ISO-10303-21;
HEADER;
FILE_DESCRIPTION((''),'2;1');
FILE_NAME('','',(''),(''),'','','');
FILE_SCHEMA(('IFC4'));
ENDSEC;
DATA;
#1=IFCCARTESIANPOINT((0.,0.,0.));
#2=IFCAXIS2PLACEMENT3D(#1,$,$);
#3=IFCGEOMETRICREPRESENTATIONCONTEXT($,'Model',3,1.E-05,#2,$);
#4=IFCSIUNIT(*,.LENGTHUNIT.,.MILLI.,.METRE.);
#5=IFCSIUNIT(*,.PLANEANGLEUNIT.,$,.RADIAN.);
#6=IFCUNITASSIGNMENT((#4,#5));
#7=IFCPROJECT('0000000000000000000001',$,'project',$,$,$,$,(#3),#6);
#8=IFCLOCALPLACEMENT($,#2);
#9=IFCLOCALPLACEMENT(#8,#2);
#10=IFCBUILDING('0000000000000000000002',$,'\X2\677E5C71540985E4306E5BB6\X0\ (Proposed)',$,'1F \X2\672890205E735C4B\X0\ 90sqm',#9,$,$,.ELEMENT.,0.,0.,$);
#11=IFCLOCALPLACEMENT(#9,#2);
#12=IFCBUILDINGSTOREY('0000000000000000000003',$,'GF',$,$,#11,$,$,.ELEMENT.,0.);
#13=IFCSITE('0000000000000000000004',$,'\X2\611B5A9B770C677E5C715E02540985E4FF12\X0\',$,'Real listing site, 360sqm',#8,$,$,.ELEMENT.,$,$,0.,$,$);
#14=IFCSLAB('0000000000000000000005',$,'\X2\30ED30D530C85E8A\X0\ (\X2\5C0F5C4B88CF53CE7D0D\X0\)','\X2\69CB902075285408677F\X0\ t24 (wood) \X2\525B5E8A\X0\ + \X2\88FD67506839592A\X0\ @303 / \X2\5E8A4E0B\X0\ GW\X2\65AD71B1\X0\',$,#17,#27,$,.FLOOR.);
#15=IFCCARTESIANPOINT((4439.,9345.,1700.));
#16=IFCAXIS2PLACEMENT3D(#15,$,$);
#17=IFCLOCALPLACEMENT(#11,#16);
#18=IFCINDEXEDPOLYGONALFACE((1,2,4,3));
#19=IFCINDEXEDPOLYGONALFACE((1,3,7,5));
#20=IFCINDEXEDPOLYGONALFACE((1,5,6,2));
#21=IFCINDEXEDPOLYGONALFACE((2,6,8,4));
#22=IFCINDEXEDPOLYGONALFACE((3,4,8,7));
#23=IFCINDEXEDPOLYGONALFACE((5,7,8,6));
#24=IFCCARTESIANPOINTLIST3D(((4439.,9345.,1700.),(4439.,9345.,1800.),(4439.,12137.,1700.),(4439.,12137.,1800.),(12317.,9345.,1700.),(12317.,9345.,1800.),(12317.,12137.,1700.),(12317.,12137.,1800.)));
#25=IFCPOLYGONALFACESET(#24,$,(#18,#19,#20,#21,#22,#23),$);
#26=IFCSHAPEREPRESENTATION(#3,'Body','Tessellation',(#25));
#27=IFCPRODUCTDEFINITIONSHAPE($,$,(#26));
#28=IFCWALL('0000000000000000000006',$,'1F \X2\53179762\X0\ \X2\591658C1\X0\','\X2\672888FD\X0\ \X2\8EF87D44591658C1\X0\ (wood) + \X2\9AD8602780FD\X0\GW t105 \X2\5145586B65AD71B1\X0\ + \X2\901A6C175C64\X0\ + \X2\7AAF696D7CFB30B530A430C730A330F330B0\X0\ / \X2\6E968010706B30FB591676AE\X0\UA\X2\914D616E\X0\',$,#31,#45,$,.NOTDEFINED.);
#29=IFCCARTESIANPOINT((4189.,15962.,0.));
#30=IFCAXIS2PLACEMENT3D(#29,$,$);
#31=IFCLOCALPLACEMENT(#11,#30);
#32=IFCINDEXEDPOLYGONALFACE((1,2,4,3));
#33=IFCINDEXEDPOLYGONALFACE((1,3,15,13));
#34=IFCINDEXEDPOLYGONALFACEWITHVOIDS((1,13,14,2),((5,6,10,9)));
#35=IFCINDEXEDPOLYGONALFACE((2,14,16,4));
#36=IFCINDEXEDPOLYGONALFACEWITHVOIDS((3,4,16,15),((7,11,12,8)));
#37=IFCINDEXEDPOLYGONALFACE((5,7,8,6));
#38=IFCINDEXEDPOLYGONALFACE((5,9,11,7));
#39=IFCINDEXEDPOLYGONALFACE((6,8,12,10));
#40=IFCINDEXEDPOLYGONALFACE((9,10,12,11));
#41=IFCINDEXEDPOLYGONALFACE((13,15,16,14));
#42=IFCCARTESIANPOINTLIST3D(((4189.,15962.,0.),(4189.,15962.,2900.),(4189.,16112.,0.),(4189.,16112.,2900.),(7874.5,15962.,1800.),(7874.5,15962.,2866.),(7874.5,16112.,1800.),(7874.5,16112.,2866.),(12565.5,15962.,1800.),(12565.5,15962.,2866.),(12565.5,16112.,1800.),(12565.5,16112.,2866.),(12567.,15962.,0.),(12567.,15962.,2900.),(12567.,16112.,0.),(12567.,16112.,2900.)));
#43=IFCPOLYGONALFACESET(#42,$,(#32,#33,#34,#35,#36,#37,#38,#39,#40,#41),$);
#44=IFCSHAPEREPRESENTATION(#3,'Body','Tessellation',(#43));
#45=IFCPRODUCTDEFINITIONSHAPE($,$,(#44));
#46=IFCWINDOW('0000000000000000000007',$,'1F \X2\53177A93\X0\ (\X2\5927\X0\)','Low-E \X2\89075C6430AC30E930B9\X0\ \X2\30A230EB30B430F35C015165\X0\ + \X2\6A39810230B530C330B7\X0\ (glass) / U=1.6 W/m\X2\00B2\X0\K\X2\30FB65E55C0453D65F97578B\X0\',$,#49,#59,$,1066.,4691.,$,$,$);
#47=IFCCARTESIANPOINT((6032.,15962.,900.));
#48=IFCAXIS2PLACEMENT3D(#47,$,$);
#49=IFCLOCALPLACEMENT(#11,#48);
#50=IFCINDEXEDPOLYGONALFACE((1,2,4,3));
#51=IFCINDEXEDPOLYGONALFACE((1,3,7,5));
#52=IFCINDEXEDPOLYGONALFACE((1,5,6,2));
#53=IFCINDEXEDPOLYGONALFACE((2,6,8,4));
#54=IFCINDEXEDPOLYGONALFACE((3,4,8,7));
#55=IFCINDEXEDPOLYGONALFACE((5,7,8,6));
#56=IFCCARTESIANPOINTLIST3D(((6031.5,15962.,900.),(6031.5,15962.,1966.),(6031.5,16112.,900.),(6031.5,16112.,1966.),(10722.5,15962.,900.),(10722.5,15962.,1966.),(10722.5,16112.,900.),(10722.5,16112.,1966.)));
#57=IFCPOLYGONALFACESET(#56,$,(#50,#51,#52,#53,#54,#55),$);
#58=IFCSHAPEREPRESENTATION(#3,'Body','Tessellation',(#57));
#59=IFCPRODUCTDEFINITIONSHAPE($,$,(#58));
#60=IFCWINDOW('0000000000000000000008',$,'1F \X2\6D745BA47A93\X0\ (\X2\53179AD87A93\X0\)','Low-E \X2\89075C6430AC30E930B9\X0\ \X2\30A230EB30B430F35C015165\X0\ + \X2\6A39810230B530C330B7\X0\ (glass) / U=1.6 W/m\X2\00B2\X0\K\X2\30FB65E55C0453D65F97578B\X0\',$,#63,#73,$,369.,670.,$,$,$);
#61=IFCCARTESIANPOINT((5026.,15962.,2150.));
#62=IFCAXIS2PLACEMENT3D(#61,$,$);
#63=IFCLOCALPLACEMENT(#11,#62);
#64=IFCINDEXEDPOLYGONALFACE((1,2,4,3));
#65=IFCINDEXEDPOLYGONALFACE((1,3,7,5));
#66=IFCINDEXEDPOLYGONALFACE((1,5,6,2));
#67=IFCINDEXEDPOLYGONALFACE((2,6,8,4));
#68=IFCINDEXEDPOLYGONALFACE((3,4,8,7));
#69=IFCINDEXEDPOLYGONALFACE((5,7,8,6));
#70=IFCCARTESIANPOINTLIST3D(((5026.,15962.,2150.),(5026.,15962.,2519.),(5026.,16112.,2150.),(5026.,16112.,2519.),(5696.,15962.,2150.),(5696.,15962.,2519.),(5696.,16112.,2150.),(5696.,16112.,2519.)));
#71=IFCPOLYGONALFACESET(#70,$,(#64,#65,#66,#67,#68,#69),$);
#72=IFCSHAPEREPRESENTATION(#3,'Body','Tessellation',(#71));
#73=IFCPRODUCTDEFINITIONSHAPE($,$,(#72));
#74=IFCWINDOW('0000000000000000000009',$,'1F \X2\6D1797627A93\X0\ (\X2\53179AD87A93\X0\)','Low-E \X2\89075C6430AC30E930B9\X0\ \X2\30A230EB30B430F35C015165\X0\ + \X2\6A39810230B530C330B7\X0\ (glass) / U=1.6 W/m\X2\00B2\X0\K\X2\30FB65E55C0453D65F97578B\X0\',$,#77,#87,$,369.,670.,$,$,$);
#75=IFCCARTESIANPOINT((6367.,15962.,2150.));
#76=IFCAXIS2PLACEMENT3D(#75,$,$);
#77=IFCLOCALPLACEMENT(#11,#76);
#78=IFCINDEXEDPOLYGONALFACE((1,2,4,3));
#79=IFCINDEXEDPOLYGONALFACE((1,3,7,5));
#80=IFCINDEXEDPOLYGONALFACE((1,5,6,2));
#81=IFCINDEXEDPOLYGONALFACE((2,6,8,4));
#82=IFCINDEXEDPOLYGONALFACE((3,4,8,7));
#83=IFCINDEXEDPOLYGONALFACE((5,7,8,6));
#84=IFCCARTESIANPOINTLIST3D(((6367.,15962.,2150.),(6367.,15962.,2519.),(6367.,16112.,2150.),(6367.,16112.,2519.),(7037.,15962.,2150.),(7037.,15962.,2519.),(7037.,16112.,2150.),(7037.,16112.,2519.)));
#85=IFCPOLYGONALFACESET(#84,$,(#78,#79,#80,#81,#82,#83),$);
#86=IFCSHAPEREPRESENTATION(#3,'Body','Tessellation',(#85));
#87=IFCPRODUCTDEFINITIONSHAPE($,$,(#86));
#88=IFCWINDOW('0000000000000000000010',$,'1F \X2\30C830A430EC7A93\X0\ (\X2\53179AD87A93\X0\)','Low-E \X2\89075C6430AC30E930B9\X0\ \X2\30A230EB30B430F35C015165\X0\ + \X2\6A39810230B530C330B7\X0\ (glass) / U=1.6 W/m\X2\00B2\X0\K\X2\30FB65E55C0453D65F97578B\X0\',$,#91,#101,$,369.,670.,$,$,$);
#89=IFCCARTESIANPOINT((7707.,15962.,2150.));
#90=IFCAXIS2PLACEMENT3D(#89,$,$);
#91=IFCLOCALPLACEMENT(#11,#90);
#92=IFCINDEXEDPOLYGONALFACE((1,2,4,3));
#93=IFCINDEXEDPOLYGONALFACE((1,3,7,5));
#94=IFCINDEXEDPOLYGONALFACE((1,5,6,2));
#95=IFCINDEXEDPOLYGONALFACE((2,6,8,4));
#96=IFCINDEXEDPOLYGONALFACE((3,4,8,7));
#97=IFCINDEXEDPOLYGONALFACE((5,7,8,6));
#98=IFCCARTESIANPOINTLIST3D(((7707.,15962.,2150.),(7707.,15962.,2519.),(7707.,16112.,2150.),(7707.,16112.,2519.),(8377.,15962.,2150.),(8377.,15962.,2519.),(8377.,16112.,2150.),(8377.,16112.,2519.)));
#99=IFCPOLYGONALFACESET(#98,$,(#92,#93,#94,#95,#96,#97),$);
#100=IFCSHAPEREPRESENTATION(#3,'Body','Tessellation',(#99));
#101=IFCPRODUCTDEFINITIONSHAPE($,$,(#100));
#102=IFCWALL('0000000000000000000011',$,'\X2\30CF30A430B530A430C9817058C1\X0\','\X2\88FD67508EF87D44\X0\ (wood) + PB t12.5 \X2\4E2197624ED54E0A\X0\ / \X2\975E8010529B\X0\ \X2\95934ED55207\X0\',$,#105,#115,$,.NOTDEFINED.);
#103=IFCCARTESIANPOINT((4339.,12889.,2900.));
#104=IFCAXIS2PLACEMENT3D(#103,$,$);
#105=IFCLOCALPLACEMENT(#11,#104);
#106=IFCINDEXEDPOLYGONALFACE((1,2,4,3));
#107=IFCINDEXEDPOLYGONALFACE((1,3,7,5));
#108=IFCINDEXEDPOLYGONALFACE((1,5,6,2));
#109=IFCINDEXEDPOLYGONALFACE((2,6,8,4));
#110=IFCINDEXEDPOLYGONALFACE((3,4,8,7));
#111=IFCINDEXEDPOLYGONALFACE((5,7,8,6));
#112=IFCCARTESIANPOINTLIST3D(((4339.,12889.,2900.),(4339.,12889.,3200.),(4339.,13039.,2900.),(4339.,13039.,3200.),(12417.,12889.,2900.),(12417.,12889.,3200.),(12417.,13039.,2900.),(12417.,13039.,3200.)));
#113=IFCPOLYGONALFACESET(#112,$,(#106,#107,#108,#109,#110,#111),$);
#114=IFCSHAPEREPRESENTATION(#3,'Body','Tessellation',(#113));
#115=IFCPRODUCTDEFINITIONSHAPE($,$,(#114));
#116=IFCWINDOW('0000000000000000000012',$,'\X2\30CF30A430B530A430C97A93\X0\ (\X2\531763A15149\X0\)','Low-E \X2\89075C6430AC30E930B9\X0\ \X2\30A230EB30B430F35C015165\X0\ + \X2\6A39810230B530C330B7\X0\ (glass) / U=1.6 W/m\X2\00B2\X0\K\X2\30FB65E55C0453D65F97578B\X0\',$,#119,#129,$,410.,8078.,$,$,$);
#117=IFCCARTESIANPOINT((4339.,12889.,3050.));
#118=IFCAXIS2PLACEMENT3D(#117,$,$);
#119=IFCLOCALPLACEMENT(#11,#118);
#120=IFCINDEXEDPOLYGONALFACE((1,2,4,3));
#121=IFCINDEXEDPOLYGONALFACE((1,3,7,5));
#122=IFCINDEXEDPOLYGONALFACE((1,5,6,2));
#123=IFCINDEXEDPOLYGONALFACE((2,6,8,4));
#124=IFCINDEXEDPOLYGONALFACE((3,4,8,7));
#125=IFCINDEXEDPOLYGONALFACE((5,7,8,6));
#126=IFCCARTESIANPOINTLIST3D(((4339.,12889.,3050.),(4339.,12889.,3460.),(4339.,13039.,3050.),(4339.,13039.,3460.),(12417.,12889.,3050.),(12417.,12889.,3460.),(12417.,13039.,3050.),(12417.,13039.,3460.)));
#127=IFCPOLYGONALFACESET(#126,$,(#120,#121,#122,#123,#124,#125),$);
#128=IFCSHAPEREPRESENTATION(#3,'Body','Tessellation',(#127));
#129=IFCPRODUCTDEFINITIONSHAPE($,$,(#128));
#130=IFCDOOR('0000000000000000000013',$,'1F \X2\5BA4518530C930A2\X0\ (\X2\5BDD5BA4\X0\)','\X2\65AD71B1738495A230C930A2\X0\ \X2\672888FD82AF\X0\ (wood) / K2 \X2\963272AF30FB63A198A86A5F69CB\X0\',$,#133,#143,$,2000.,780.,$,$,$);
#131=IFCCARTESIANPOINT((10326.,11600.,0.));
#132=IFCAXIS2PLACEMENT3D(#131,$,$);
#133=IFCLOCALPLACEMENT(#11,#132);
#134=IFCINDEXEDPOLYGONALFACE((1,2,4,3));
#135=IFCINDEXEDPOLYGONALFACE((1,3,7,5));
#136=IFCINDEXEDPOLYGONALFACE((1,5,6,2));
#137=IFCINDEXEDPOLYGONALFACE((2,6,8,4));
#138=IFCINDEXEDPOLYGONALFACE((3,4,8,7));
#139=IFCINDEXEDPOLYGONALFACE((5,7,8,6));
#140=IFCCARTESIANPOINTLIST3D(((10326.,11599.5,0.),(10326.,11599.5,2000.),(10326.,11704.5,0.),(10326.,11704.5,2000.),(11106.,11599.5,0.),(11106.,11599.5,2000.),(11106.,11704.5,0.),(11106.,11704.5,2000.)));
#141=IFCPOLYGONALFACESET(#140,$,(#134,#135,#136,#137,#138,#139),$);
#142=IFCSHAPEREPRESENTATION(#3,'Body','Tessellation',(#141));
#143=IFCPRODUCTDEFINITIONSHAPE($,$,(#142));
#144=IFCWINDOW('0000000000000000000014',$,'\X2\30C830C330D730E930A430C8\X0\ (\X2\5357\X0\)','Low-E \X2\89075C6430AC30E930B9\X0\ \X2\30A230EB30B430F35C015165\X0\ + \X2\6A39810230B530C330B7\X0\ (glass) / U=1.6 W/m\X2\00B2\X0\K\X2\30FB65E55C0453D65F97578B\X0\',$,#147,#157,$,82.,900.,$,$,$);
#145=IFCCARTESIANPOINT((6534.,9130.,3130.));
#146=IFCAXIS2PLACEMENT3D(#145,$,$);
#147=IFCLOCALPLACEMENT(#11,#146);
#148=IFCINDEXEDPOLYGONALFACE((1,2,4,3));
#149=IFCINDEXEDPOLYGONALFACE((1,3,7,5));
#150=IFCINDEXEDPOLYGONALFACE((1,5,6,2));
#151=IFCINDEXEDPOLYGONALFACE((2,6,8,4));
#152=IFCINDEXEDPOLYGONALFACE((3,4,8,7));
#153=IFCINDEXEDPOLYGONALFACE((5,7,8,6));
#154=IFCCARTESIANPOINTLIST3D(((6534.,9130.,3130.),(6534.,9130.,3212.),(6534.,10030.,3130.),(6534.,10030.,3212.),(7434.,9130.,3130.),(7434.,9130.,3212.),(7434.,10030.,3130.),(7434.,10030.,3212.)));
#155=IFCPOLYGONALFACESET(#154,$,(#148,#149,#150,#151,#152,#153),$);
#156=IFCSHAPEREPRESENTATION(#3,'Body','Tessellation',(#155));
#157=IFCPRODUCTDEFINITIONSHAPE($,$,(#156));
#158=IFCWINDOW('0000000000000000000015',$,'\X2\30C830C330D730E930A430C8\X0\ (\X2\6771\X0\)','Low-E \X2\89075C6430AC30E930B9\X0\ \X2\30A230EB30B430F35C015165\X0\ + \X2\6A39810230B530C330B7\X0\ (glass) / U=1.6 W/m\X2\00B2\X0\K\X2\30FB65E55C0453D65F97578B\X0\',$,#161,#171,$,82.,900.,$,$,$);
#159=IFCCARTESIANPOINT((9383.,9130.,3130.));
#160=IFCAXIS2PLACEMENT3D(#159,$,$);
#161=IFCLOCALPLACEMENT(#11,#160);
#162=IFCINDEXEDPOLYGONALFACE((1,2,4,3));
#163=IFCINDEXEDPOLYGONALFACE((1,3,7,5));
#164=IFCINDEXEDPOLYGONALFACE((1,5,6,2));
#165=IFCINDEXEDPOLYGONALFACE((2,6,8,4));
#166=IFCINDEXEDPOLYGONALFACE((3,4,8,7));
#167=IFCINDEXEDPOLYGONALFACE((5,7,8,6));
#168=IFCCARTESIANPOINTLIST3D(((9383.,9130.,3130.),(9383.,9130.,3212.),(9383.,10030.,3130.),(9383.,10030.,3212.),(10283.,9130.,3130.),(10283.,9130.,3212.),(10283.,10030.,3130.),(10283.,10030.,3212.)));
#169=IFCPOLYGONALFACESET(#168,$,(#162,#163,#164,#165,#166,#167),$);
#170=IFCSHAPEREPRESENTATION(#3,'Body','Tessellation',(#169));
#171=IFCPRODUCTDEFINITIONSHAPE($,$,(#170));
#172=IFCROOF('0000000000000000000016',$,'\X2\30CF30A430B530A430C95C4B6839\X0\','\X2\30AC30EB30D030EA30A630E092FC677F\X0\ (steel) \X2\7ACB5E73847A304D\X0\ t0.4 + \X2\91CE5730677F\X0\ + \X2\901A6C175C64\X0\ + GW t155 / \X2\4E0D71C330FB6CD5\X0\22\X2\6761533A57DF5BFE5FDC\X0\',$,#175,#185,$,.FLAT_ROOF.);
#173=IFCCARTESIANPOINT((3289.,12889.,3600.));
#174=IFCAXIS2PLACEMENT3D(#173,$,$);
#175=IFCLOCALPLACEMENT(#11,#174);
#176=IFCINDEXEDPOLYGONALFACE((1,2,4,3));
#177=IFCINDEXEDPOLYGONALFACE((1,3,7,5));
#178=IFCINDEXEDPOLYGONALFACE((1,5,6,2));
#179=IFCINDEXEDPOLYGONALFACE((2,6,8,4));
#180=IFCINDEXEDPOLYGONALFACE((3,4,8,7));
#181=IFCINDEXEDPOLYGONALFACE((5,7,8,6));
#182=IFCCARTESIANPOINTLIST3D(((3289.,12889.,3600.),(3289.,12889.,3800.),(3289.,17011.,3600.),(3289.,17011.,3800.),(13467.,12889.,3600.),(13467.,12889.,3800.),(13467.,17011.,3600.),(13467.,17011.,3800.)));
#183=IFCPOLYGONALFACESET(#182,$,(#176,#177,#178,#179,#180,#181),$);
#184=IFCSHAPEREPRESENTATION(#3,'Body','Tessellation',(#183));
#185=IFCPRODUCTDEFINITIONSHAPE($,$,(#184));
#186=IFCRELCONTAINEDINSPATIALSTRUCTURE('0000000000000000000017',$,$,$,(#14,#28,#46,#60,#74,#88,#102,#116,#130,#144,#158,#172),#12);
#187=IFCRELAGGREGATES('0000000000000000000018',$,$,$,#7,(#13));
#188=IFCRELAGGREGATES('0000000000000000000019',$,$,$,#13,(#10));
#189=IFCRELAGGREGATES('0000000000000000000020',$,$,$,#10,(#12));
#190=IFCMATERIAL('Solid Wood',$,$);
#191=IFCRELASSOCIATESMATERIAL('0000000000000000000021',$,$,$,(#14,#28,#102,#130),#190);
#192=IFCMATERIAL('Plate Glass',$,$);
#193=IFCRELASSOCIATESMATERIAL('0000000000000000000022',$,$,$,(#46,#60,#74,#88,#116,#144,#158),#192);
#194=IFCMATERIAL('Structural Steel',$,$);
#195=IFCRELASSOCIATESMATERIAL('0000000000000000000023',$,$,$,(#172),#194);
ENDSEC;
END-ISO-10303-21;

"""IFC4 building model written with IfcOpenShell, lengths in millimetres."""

from ifc_helpers import new_model, si_unit, frame, frame_2d, origin, place, context, project, spatial, rectangle, extrude, material, element, fill, save


model = new_model("IFC4")

# Units and contexts
model_context = context("Model", 3, precision=1e-05, world=origin())
ifc_project = project(units=[si_unit("LENGTHUNIT", "METRE", prefix="MILLI"), si_unit("PLANEANGLEUNIT", "RADIAN")], contexts=[model_context])

# Site, building, storey
site_placement = place(None, origin())
site = spatial("IfcSite", under=ifc_project, at=site_placement, Name="愛媛県松山市吉藤２", ObjectType="Real listing site, 360sqm", CompositionType="ELEMENT", RefElevation=0.0)
building_placement = place(site_placement, origin())
building = spatial("IfcBuilding", under=site, at=building_placement, Name="松山吉藤の家 (Proposed)", ObjectType="1F 木造平屋 90sqm", CompositionType="ELEMENT", ElevationOfRefHeight=0.0, ElevationOfTerrain=0.0)
storey_placement = place(building_placement, origin())
storey = spatial("IfcBuildingStorey", under=building, at=storey_placement, Name="GF", CompositionType="ELEMENT", Elevation=0.0)

# Slab
ifc_material_1 = material(Name="Solid Wood")
slab_placement = place(storey_placement, frame((4439.0, 9345.0, 1700.0)))
element("IfcSlab", 1, at=slab_placement, inside=storey, material=ifc_material_1, Name="ロフト床 (小屋裏収納)", Description="構造用合板 t24 (wood) 剛床 + 製材根太 @303 / 床下 GW断熱", PredefinedType="FLOOR", context=model_context, shape_type="SweptSolid", body=[
    extrude(rectangle(XDim=7878.0, YDim=2792.0, at=frame_2d((3939.0, 1396.0))), frame((4439.0, 9345.0, 1700.0)), (0.0, 0.0, 1.0), 100.0),
])

# Wall, openings, windows
wall_1_placement = place(storey_placement, frame((4189.0, 15962.0, 0.0)))
wall_1 = element("IfcWall", 2, at=wall_1_placement, inside=storey, material=ifc_material_1, Name="1F 北面 外壁", Description="木製 軸組外壁 (wood) + 高性能GW t105 充填断熱 + 通気層 + 窯業系サイディング / 準耐火・外皮UA配慮", PredefinedType="NOTDEFINED", context=model_context, shape_type="SweptSolid", body=[
    extrude(rectangle(XDim=8378.0, YDim=150.0, at=frame_2d((4189.0, 75.0))), frame((4189.0, 15962.0, 0.0)), (0.0, 0.0, 1.0), 2900.0),
])
opening_1_placement = place(storey_placement, frame((6032.0, 15962.0, 900.0)))
opening_1 = element("IfcOpeningElement", 3, at=opening_1_placement, cuts=wall_1, PredefinedType="NOTDEFINED", context=model_context, shape_type="SweptSolid", body=[
    extrude(rectangle(XDim=4691.0, YDim=150.0, at=frame_2d((2345.0, 75.0))), frame((6032.0, 15962.0, 900.0)), (0.0, 0.0, 1.0), 1066.0),
])
opening_2_placement = place(storey_placement, frame((5026.0, 15962.0, 2150.0)))
opening_2 = element("IfcOpeningElement", 4, at=opening_2_placement, cuts=wall_1, PredefinedType="NOTDEFINED", context=model_context, shape_type="SweptSolid", body=[
    extrude(rectangle(XDim=670.0, YDim=150.0, at=frame_2d((335.0, 75.0))), frame((5026.0, 15962.0, 2150.0)), (0.0, 0.0, 1.0), 369.0),
])
opening_3_placement = place(storey_placement, frame((6367.0, 15962.0, 2150.0)))
opening_3 = element("IfcOpeningElement", 5, at=opening_3_placement, cuts=wall_1, PredefinedType="NOTDEFINED", context=model_context, shape_type="SweptSolid", body=[
    extrude(rectangle(XDim=670.0, YDim=150.0, at=frame_2d((335.0, 75.0))), frame((6367.0, 15962.0, 2150.0)), (0.0, 0.0, 1.0), 369.0),
])
opening_4_placement = place(storey_placement, frame((7707.0, 15962.0, 2150.0)))
opening_4 = element("IfcOpeningElement", 6, at=opening_4_placement, cuts=wall_1, PredefinedType="NOTDEFINED", context=model_context, shape_type="SweptSolid", body=[
    extrude(rectangle(XDim=670.0, YDim=150.0, at=frame_2d((335.0, 75.0))), frame((7707.0, 15962.0, 2150.0)), (0.0, 0.0, 1.0), 369.0),
])
ifc_material_2 = material(Name="Plate Glass")
window_1_placement = place(storey_placement, frame((6032.0, 15962.0, 900.0)))
window_1 = element("IfcWindow", 7, at=window_1_placement, inside=storey, material=ifc_material_2, Name="1F 北窓 (大)", Description="Low-E 複層ガラス アルゴン封入 + 樹脂サッシ (glass) / U=1.6 W/m²K・日射取得型", OverallHeight=1066.0, OverallWidth=4691.0, context=model_context, shape_type="SweptSolid", body=[
    extrude(rectangle(XDim=4691.0, YDim=150.0, at=frame_2d((2345.0, 75.0))), frame((6032.0, 15962.0, 900.0)), (0.0, 0.0, 1.0), 1066.0),
])
fill(opening_1, window_1)
window_2_placement = place(storey_placement, frame((5026.0, 15962.0, 2150.0)))
window_2 = element("IfcWindow", 8, at=window_2_placement, inside=storey, material=ifc_material_2, Name="1F 浴室窓 (北高窓)", Description="Low-E 複層ガラス アルゴン封入 + 樹脂サッシ (glass) / U=1.6 W/m²K・日射取得型", OverallHeight=369.0, OverallWidth=670.0, context=model_context, shape_type="SweptSolid", body=[
    extrude(rectangle(XDim=670.0, YDim=150.0, at=frame_2d((335.0, 75.0))), frame((5026.0, 15962.0, 2150.0)), (0.0, 0.0, 1.0), 369.0),
])
fill(opening_2, window_2)
window_3_placement = place(storey_placement, frame((6367.0, 15962.0, 2150.0)))
window_3 = element("IfcWindow", 9, at=window_3_placement, inside=storey, material=ifc_material_2, Name="1F 洗面窓 (北高窓)", Description="Low-E 複層ガラス アルゴン封入 + 樹脂サッシ (glass) / U=1.6 W/m²K・日射取得型", OverallHeight=369.0, OverallWidth=670.0, context=model_context, shape_type="SweptSolid", body=[
    extrude(rectangle(XDim=670.0, YDim=150.0, at=frame_2d((335.0, 75.0))), frame((6367.0, 15962.0, 2150.0)), (0.0, 0.0, 1.0), 369.0),
])
fill(opening_3, window_3)
window_4_placement = place(storey_placement, frame((7707.0, 15962.0, 2150.0)))
window_4 = element("IfcWindow", 10, at=window_4_placement, inside=storey, material=ifc_material_2, Name="1F トイレ窓 (北高窓)", Description="Low-E 複層ガラス アルゴン封入 + 樹脂サッシ (glass) / U=1.6 W/m²K・日射取得型", OverallHeight=369.0, OverallWidth=670.0, context=model_context, shape_type="SweptSolid", body=[
    extrude(rectangle(XDim=670.0, YDim=150.0, at=frame_2d((335.0, 75.0))), frame((7707.0, 15962.0, 2150.0)), (0.0, 0.0, 1.0), 369.0),
])
fill(opening_4, window_4)

# Wall, opening, window
wall_2_placement = place(storey_placement, frame((4339.0, 12889.0, 2900.0)))
wall_2 = element("IfcWall", 11, at=wall_2_placement, inside=storey, material=ifc_material_1, Name="ハイサイド腰壁", Description="製材軸組 (wood) + PB t12.5 両面仕上 / 非耐力 間仕切", PredefinedType="NOTDEFINED", context=model_context, shape_type="SweptSolid", body=[
    extrude(rectangle(XDim=8078.0, YDim=150.0, at=frame_2d((4039.0, 75.0))), frame((4339.0, 12889.0, 2900.0)), (0.0, 0.0, 1.0), 700.0),
])
opening_5_placement = place(storey_placement, frame((4339.0, 12889.0, 3050.0)))
opening_5 = element("IfcOpeningElement", 12, at=opening_5_placement, cuts=wall_2, PredefinedType="NOTDEFINED", context=model_context, shape_type="SweptSolid", body=[
    extrude(rectangle(XDim=8078.0, YDim=150.0, at=frame_2d((4039.0, 75.0))), frame((4339.0, 12889.0, 3050.0)), (0.0, 0.0, 1.0), 410.0),
])
window_5_placement = place(storey_placement, frame((4339.0, 12889.0, 3050.0)))
window_5 = element("IfcWindow", 13, at=window_5_placement, inside=storey, material=ifc_material_2, Name="ハイサイド窓 (北採光)", Description="Low-E 複層ガラス アルゴン封入 + 樹脂サッシ (glass) / U=1.6 W/m²K・日射取得型", OverallHeight=410.0, OverallWidth=8078.0, context=model_context, shape_type="SweptSolid", body=[
    extrude(rectangle(XDim=8078.0, YDim=150.0, at=frame_2d((4039.0, 75.0))), frame((4339.0, 12889.0, 3050.0)), (0.0, 0.0, 1.0), 410.0),
])
fill(opening_5, window_5)

# Door
door_1_placement = place(storey_placement, frame((10326.0, 11600.0, 0.0)))
element("IfcDoor", 14, at=door_1_placement, inside=storey, material=ifc_material_1, Name="1F 室内ドア (寝室)", Description="断熱玄関ドア 木製芯 (wood) / K2 防犯・採風機構", OverallHeight=2000.0, OverallWidth=780.0, context=model_context, shape_type="SweptSolid", body=[
    extrude(rectangle(XDim=780.0, YDim=105.0, at=frame_2d((390.0, 52.0))), frame((10326.0, 11600.0, 0.0)), (0.0, 0.0, 1.0), 2000.0),
])

# Windows
window_6_placement = place(storey_placement, frame((6534.0, 9130.0, 3130.0)))
element("IfcWindow", 15, at=window_6_placement, inside=storey, material=ifc_material_2, Name="トップライト (南)", Description="Low-E 複層ガラス アルゴン封入 + 樹脂サッシ (glass) / U=1.6 W/m²K・日射取得型", OverallHeight=82.0, OverallWidth=900.0, context=model_context, shape_type="SweptSolid", body=[
    extrude(rectangle(XDim=900.0, YDim=900.0, at=frame_2d((450.0, 450.0))), frame((6534.0, 9130.0, 3130.0)), (0.0, 0.0, 1.0), 82.0),
])
window_7_placement = place(storey_placement, frame((9383.0, 9130.0, 3130.0)))
element("IfcWindow", 16, at=window_7_placement, inside=storey, material=ifc_material_2, Name="トップライト (東)", Description="Low-E 複層ガラス アルゴン封入 + 樹脂サッシ (glass) / U=1.6 W/m²K・日射取得型", OverallHeight=82.0, OverallWidth=900.0, context=model_context, shape_type="SweptSolid", body=[
    extrude(rectangle(XDim=900.0, YDim=900.0, at=frame_2d((450.0, 450.0))), frame((9383.0, 9130.0, 3130.0)), (0.0, 0.0, 1.0), 82.0),
])

# Roof
ifc_material_3 = material(Name="Structural Steel")
roof_placement = place(storey_placement, frame((3289.0, 12889.0, 3600.0)))
element("IfcRoof", 17, at=roof_placement, inside=storey, material=ifc_material_3, Name="ハイサイド屋根", Description="ガルバリウム鋼板 (steel) 立平葺き t0.4 + 野地板 + 通気層 + GW t155 / 不燃・法22条区域対応", PredefinedType="FLAT_ROOF", context=model_context, shape_type="SweptSolid", body=[
    extrude(rectangle(XDim=10178.0, YDim=4122.0, at=frame_2d((5089.0, 2061.0))), frame((3289.0, 12889.0, 3600.0)), (0.0, 0.0, 1.0), 200.0),
])

save(model, "model.ifc")
